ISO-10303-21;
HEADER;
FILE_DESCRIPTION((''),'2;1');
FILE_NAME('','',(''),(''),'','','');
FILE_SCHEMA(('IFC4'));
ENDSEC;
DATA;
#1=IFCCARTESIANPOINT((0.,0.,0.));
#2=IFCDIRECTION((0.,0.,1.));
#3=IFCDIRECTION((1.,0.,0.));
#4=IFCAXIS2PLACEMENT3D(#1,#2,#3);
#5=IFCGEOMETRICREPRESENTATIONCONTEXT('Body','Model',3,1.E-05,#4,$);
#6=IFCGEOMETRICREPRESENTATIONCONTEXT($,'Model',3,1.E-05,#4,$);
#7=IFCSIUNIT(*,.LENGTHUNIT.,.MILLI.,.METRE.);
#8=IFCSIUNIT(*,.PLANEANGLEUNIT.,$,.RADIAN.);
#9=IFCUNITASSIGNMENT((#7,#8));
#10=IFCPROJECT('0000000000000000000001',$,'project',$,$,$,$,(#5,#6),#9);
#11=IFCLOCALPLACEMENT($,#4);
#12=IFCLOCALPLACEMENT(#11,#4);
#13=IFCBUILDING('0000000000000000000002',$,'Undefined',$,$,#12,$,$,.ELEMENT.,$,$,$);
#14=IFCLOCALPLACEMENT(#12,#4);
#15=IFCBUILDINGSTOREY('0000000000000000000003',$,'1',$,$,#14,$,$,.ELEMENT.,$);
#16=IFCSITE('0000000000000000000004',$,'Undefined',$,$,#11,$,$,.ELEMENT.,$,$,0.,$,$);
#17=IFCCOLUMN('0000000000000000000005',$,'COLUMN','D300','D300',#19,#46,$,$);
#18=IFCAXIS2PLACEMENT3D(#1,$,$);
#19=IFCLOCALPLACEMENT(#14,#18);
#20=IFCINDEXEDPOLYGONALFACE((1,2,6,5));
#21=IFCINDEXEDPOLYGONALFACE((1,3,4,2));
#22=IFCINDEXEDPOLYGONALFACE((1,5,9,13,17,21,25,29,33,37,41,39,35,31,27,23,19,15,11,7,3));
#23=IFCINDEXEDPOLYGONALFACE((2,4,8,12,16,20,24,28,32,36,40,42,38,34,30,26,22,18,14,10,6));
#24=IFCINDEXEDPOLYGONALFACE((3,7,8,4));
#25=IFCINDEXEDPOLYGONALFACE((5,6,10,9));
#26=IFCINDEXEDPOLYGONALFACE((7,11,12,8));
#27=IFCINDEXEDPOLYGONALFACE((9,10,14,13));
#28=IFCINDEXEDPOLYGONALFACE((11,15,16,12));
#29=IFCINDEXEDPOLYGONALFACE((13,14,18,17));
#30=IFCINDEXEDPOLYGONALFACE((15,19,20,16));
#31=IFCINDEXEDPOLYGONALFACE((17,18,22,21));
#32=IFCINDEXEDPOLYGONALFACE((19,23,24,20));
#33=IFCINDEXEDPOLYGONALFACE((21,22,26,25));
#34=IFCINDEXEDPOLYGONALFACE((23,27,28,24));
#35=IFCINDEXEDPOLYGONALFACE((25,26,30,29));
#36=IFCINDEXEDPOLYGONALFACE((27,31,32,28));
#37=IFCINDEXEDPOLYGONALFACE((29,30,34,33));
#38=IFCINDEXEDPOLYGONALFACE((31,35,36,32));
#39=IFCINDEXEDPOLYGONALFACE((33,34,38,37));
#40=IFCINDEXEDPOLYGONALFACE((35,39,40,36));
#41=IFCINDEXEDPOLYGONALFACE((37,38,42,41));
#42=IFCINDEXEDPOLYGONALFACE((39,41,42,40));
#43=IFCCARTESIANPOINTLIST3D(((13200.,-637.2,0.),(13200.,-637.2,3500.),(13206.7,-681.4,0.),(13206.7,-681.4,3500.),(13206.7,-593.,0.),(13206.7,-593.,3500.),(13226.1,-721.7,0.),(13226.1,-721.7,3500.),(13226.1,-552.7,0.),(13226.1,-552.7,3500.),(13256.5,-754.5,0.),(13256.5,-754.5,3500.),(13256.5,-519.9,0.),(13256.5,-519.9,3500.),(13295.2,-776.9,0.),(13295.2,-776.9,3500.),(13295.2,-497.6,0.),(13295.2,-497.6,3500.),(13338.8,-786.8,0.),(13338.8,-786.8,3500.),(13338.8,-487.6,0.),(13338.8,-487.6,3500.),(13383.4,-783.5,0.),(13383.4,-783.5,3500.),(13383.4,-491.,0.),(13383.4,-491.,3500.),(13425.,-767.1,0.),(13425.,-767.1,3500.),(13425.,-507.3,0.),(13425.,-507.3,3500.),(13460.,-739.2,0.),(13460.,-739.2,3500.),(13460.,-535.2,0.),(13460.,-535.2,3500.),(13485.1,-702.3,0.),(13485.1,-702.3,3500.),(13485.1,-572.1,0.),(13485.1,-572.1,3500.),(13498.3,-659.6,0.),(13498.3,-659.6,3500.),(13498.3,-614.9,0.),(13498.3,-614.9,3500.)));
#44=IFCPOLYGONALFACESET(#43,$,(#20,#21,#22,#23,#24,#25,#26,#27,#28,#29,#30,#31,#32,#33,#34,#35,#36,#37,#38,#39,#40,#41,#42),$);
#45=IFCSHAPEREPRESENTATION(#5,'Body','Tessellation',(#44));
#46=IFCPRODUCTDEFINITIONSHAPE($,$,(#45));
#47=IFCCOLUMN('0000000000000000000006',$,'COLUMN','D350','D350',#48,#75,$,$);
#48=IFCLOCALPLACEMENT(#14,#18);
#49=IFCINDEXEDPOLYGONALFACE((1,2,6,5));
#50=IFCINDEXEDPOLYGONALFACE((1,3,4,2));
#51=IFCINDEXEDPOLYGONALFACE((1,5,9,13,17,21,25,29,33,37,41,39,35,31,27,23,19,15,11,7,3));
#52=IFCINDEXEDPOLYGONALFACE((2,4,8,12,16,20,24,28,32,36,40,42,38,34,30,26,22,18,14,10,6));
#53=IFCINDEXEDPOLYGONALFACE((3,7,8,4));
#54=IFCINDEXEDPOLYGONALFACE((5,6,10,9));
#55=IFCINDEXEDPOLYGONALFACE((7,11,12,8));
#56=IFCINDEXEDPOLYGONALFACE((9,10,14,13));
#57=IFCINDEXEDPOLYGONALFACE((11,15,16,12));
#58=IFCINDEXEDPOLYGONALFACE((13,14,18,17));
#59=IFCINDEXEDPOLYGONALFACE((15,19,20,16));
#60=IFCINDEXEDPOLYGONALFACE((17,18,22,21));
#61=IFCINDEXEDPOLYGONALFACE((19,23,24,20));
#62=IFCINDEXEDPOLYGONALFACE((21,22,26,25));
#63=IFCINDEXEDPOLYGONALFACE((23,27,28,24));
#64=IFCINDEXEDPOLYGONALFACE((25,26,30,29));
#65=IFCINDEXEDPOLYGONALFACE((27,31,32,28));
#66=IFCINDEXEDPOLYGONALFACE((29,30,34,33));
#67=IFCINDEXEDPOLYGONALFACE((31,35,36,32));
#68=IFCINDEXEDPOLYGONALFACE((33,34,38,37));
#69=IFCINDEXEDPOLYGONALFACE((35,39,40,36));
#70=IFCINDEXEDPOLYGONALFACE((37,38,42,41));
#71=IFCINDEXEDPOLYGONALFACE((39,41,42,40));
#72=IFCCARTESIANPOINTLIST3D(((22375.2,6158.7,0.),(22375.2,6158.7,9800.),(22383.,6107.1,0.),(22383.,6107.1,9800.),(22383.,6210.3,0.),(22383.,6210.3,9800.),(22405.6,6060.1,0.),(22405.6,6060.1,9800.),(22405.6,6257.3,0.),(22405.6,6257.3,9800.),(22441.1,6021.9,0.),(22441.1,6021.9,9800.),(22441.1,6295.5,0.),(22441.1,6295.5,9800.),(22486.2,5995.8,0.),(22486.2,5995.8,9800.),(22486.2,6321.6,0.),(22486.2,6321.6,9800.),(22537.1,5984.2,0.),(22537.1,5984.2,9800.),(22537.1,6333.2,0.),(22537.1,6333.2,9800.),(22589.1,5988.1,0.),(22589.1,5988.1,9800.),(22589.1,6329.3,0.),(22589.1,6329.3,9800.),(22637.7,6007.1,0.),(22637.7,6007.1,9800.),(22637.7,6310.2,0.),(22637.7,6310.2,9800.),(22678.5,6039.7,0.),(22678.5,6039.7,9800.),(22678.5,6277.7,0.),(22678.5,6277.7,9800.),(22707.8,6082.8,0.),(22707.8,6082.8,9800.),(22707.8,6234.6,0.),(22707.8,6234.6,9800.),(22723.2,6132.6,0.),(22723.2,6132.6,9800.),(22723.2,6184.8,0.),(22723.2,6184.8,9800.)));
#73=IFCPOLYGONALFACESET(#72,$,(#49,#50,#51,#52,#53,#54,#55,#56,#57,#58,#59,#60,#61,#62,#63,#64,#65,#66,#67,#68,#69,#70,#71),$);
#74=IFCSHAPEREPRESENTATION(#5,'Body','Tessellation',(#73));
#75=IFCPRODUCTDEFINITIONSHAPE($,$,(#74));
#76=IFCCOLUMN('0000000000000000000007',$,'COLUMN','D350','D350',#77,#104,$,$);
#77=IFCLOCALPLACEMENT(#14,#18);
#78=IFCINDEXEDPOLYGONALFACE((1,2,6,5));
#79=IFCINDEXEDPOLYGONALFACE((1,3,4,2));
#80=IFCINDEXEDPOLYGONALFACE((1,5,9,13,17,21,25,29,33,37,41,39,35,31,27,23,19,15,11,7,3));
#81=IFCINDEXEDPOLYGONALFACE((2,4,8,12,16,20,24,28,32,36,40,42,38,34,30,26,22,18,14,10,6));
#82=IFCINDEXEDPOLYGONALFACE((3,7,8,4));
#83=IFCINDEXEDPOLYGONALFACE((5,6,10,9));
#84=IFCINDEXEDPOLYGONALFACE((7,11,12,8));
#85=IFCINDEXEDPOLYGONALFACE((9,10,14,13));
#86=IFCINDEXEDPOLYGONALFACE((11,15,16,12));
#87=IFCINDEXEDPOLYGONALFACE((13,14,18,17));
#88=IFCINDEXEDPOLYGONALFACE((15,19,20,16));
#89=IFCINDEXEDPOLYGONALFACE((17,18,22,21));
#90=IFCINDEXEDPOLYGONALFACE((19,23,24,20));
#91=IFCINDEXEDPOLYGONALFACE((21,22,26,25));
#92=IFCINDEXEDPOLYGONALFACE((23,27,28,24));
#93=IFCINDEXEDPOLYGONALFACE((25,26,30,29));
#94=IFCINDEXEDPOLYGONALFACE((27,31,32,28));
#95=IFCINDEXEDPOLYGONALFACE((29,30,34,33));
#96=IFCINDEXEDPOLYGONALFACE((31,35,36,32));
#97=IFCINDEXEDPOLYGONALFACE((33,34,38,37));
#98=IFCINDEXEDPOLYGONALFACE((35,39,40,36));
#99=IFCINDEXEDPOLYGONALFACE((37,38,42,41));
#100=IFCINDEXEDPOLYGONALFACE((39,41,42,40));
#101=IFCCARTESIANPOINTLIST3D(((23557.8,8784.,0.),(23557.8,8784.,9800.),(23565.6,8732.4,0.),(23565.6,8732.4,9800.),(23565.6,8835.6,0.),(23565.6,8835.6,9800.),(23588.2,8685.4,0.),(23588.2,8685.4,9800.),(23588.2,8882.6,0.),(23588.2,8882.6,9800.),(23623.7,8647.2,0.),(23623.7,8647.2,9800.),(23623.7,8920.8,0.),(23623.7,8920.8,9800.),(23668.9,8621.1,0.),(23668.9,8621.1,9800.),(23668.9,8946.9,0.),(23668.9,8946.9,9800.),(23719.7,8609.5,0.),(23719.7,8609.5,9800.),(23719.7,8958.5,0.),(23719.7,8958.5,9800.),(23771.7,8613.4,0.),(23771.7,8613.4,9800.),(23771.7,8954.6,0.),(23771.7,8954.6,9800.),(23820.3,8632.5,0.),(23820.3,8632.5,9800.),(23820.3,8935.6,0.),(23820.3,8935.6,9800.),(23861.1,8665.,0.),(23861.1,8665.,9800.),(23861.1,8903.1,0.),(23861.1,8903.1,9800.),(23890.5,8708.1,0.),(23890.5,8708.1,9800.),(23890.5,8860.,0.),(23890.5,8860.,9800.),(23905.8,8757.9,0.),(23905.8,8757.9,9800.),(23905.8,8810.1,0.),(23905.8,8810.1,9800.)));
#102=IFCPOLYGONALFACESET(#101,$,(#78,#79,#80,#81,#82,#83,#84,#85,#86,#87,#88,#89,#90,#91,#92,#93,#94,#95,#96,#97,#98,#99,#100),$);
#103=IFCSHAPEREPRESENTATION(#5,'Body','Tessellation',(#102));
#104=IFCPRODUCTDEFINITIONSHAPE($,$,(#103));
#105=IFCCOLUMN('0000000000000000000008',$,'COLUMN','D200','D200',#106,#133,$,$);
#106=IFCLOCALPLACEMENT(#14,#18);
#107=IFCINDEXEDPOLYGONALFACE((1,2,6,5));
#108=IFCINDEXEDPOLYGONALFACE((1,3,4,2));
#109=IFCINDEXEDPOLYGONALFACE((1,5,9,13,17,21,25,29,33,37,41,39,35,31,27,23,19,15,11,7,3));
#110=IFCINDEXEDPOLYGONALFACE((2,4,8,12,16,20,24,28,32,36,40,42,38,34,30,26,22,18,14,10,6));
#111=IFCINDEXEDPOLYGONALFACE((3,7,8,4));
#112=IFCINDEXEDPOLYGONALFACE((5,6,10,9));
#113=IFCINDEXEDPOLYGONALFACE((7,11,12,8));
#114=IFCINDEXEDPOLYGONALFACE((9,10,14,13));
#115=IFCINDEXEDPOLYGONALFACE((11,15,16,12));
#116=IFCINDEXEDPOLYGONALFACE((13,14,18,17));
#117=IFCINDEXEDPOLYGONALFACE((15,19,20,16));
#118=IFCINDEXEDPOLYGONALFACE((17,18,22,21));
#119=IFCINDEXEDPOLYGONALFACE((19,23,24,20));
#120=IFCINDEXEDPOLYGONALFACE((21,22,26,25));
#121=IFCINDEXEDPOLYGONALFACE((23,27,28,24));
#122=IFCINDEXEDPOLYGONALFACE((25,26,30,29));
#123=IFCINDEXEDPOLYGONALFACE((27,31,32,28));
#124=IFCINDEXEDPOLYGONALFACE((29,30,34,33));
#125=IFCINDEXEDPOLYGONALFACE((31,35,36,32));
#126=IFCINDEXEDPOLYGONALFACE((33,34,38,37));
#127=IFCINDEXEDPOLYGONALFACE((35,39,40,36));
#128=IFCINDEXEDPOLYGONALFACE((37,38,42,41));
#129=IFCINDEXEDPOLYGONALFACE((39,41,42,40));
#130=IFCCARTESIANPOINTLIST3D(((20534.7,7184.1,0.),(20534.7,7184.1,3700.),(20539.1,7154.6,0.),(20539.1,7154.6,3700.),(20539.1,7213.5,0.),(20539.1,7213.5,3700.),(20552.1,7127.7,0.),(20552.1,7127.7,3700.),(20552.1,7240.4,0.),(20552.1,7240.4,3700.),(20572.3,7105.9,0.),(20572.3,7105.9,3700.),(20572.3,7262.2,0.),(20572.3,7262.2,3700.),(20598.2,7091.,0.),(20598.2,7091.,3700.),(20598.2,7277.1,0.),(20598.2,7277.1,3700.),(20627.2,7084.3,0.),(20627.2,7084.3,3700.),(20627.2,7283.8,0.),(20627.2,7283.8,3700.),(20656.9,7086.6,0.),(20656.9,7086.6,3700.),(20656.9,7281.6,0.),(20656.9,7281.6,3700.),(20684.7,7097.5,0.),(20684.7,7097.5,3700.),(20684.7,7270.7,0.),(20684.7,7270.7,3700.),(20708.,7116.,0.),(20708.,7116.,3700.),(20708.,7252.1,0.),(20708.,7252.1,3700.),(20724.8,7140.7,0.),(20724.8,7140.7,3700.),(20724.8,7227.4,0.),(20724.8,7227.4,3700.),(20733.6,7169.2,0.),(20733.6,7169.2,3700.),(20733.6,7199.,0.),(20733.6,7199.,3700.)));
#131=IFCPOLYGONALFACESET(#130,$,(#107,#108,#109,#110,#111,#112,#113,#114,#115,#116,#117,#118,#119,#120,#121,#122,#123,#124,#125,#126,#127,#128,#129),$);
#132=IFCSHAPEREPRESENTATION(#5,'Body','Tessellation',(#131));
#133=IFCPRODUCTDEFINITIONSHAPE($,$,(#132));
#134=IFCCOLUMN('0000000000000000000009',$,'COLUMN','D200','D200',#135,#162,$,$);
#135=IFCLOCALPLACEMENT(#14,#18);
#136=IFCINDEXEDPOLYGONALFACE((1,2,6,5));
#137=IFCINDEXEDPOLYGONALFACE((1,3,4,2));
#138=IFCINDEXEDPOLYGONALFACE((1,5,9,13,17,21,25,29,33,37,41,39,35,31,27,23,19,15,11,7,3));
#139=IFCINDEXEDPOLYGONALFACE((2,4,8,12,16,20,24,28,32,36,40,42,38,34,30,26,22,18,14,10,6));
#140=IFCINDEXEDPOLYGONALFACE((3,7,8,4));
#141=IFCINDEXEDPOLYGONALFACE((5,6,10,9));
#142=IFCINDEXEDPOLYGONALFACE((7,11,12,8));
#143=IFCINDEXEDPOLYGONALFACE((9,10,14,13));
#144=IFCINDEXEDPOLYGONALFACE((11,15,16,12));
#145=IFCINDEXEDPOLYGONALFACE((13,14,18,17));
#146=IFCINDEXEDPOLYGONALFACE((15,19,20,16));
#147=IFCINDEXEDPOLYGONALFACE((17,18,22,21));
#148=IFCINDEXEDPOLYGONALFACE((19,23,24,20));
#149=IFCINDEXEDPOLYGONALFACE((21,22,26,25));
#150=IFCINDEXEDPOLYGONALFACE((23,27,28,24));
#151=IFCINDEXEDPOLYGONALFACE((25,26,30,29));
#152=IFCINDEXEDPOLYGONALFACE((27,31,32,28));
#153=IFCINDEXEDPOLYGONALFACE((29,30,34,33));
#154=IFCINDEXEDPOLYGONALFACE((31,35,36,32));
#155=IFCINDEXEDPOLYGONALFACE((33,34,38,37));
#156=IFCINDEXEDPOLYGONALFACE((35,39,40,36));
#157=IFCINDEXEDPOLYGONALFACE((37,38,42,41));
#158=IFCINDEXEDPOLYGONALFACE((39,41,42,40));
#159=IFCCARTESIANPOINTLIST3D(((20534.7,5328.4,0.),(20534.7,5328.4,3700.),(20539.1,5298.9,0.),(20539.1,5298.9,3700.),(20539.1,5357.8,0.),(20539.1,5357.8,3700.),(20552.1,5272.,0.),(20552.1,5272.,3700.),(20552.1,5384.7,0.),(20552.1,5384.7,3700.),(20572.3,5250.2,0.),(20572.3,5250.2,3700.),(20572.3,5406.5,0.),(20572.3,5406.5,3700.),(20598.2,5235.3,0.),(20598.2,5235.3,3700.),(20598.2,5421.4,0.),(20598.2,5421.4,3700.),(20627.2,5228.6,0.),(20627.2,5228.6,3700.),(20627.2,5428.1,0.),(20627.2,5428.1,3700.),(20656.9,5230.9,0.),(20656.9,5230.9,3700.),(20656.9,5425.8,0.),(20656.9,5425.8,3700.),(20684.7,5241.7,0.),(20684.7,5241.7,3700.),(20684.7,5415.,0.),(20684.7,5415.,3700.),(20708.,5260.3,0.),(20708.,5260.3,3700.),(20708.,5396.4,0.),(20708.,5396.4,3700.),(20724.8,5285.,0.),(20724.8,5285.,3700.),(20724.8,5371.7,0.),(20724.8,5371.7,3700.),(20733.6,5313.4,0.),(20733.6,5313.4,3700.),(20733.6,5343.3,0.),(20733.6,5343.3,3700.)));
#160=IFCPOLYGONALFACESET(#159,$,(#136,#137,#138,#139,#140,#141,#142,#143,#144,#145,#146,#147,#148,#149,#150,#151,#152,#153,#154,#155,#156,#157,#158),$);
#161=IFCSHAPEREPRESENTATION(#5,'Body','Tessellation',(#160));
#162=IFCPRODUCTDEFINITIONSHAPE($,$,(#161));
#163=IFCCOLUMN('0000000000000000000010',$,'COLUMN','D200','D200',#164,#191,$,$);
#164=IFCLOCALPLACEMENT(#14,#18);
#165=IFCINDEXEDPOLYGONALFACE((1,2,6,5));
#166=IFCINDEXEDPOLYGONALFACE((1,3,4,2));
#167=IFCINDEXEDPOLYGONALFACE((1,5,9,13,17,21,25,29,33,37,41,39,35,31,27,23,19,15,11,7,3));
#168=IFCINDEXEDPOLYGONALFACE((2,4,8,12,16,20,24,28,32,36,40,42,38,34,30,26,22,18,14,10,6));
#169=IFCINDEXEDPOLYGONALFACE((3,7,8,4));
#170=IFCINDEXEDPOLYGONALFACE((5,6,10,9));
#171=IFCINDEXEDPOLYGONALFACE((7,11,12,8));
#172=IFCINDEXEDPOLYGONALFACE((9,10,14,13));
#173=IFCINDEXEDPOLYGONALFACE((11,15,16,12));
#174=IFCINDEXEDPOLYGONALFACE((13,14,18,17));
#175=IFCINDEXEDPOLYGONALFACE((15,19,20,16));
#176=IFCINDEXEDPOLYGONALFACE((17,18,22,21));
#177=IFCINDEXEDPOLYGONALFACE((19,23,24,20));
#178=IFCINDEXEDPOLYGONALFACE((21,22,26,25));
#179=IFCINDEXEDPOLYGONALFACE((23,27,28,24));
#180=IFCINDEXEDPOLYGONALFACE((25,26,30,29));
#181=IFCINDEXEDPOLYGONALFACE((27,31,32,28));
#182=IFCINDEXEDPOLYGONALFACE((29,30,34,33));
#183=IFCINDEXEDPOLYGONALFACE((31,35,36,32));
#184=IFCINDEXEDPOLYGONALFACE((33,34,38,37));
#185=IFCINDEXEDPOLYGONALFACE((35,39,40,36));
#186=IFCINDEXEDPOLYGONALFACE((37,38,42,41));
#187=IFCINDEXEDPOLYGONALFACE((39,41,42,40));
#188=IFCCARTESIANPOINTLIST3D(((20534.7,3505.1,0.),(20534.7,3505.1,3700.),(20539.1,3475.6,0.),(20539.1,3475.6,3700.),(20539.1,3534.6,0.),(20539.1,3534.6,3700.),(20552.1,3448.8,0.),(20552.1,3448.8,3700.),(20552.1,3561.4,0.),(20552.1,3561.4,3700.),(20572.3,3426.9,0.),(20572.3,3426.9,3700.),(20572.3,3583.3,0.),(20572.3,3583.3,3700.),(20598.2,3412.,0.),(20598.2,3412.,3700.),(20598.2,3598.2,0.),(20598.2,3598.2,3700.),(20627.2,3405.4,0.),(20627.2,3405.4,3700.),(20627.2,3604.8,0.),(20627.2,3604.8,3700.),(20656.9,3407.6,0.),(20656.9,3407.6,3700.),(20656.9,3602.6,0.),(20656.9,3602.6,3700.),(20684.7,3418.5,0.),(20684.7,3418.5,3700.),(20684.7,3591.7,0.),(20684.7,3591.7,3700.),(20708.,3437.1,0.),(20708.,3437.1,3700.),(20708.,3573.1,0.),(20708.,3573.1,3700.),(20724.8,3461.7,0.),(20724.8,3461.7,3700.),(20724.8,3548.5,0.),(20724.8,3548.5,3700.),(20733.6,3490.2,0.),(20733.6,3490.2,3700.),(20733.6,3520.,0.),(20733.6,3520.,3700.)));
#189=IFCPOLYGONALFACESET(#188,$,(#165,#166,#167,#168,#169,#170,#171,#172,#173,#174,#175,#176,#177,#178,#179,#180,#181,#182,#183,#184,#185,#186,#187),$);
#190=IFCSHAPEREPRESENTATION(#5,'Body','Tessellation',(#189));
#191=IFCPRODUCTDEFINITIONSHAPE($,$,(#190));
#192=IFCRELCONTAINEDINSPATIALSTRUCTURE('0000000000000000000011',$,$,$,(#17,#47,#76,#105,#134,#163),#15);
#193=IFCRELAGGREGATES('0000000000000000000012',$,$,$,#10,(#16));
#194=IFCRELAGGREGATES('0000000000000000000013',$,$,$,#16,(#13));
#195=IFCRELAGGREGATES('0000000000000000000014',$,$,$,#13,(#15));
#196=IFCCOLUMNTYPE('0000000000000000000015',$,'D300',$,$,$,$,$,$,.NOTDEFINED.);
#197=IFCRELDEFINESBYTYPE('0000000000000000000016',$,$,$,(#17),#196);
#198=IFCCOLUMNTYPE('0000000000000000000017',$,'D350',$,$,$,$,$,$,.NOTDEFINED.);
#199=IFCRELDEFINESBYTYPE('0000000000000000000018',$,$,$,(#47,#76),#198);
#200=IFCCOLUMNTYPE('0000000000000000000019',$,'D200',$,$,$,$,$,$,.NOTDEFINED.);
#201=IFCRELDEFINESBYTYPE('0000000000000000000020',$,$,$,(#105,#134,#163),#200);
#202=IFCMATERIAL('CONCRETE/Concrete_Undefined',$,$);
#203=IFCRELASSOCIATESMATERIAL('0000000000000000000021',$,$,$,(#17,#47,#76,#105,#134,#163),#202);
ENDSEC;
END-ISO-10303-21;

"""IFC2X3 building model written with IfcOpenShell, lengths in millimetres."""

from ifc_helpers import new_model, si_unit, frame, origin_with_axes, origin_2d_with_axis, place, context, project, spatial, circle, extrude, material, type_object, element, save


model = new_model("IFC2X3")

# Units and contexts
model_context_1 = context("Model", 3, precision=1e-05, world=origin_with_axes(), identifier="Body")
model_context_2 = context("Model", 3, precision=1e-05, world=origin_with_axes())
ifc_project = project(units=[si_unit("LENGTHUNIT", "METRE", prefix="MILLI"), si_unit("PLANEANGLEUNIT", "RADIAN")], contexts=[model_context_1, model_context_2])

# Site, building, storey
site_placement = place(None, origin_with_axes())
site = spatial("IfcSite", under=ifc_project, at=site_placement, Name="Undefined", CompositionType="ELEMENT", RefElevation=0.0)
building_placement = place(site_placement, origin_with_axes())
building = spatial("IfcBuilding", under=site, at=building_placement, Name="Undefined", CompositionType="ELEMENT")
storey_placement = place(building_placement, origin_with_axes())
storey = spatial("IfcBuildingStorey", under=building, at=storey_placement, Name="1", CompositionType="ELEMENT")

# Columns
ifc_material = material(Name="CONCRETE/Concrete_Undefined")
column_type_1 = type_object("IfcColumnType", Name="D300", PredefinedType="NOTDEFINED")
column_1_placement = place(storey_placement, frame((13350.0, -637.2, 0.0), z_axis=(0.0, 0.0, 1.0), x_axis=(1.0, 0.0, 0.0)))
element("IfcColumn", 1, at=column_1_placement, inside=storey, type_object=column_type_1, material=ifc_material, Name="COLUMN", Description="D300", ObjectType="D300", context=model_context_1, shape_type="SweptSolid", body=[
    extrude(circle(Radius=150.0, at=origin_2d_with_axis()), frame((0.0, 0.0, 3500.0), z_axis=(0.0, 0.0, -1.0), x_axis=(-1.0, 0.0, 0.0)), (0.0, 0.0, 1.0), 3500.0),
])
column_type_2 = type_object("IfcColumnType", Name="D350", PredefinedType="NOTDEFINED")
for number, where, z_axis, x_axis, name in (
    (2, (22550.2, 6158.7, 0.0), (0.0, 0.0, 1.0), (1.0, 0.0, 0.0), "COLUMN"),
    (3, (23732.8, 8784.0, 0.0), (0.0, 0.0, 1.0), (1.0, 0.0, 0.0), "COLUMN"),
):
    element("IfcColumn", number, at=place(storey_placement, frame(where, z_axis=z_axis, x_axis=x_axis)), inside=storey, type_object=column_type_2, material=ifc_material, Name=name, Description="D350", ObjectType="D350", context=model_context_1, shape_type="SweptSolid", body=[
        extrude(circle(Radius=175.0, at=origin_2d_with_axis()), frame((0.0, 0.0, 9800.0), z_axis=(0.0, 0.0, -1.0), x_axis=(-1.0, 0.0, 0.0)), (0.0, 0.0, 1.0), 9800.0),
    ])
column_type_3 = type_object("IfcColumnType", Name="D200", PredefinedType="NOTDEFINED")
for number, where, z_axis, x_axis, name in (
    (4, (20634.7, 7184.1, 0.0), (0.0, 0.0, 1.0), (1.0, 0.0, 0.0), "COLUMN"),
    (5, (20634.7, 5328.4, 0.0), (0.0, 0.0, 1.0), (1.0, 0.0, 0.0), "COLUMN"),
    (6, (20634.7, 3505.1, 0.0), (0.0, 0.0, 1.0), (1.0, 0.0, 0.0), "COLUMN"),
):
    element("IfcColumn", number, at=place(storey_placement, frame(where, z_axis=z_axis, x_axis=x_axis)), inside=storey, type_object=column_type_3, material=ifc_material, Name=name, Description="D200", ObjectType="D200", context=model_context_1, shape_type="SweptSolid", body=[
        extrude(circle(Radius=100.0, at=origin_2d_with_axis()), frame((0.0, 0.0, 3700.0), z_axis=(0.0, 0.0, -1.0), x_axis=(-1.0, 0.0, 0.0)), (0.0, 0.0, 1.0), 3700.0),
    ])

save(model, "model.ifc")
